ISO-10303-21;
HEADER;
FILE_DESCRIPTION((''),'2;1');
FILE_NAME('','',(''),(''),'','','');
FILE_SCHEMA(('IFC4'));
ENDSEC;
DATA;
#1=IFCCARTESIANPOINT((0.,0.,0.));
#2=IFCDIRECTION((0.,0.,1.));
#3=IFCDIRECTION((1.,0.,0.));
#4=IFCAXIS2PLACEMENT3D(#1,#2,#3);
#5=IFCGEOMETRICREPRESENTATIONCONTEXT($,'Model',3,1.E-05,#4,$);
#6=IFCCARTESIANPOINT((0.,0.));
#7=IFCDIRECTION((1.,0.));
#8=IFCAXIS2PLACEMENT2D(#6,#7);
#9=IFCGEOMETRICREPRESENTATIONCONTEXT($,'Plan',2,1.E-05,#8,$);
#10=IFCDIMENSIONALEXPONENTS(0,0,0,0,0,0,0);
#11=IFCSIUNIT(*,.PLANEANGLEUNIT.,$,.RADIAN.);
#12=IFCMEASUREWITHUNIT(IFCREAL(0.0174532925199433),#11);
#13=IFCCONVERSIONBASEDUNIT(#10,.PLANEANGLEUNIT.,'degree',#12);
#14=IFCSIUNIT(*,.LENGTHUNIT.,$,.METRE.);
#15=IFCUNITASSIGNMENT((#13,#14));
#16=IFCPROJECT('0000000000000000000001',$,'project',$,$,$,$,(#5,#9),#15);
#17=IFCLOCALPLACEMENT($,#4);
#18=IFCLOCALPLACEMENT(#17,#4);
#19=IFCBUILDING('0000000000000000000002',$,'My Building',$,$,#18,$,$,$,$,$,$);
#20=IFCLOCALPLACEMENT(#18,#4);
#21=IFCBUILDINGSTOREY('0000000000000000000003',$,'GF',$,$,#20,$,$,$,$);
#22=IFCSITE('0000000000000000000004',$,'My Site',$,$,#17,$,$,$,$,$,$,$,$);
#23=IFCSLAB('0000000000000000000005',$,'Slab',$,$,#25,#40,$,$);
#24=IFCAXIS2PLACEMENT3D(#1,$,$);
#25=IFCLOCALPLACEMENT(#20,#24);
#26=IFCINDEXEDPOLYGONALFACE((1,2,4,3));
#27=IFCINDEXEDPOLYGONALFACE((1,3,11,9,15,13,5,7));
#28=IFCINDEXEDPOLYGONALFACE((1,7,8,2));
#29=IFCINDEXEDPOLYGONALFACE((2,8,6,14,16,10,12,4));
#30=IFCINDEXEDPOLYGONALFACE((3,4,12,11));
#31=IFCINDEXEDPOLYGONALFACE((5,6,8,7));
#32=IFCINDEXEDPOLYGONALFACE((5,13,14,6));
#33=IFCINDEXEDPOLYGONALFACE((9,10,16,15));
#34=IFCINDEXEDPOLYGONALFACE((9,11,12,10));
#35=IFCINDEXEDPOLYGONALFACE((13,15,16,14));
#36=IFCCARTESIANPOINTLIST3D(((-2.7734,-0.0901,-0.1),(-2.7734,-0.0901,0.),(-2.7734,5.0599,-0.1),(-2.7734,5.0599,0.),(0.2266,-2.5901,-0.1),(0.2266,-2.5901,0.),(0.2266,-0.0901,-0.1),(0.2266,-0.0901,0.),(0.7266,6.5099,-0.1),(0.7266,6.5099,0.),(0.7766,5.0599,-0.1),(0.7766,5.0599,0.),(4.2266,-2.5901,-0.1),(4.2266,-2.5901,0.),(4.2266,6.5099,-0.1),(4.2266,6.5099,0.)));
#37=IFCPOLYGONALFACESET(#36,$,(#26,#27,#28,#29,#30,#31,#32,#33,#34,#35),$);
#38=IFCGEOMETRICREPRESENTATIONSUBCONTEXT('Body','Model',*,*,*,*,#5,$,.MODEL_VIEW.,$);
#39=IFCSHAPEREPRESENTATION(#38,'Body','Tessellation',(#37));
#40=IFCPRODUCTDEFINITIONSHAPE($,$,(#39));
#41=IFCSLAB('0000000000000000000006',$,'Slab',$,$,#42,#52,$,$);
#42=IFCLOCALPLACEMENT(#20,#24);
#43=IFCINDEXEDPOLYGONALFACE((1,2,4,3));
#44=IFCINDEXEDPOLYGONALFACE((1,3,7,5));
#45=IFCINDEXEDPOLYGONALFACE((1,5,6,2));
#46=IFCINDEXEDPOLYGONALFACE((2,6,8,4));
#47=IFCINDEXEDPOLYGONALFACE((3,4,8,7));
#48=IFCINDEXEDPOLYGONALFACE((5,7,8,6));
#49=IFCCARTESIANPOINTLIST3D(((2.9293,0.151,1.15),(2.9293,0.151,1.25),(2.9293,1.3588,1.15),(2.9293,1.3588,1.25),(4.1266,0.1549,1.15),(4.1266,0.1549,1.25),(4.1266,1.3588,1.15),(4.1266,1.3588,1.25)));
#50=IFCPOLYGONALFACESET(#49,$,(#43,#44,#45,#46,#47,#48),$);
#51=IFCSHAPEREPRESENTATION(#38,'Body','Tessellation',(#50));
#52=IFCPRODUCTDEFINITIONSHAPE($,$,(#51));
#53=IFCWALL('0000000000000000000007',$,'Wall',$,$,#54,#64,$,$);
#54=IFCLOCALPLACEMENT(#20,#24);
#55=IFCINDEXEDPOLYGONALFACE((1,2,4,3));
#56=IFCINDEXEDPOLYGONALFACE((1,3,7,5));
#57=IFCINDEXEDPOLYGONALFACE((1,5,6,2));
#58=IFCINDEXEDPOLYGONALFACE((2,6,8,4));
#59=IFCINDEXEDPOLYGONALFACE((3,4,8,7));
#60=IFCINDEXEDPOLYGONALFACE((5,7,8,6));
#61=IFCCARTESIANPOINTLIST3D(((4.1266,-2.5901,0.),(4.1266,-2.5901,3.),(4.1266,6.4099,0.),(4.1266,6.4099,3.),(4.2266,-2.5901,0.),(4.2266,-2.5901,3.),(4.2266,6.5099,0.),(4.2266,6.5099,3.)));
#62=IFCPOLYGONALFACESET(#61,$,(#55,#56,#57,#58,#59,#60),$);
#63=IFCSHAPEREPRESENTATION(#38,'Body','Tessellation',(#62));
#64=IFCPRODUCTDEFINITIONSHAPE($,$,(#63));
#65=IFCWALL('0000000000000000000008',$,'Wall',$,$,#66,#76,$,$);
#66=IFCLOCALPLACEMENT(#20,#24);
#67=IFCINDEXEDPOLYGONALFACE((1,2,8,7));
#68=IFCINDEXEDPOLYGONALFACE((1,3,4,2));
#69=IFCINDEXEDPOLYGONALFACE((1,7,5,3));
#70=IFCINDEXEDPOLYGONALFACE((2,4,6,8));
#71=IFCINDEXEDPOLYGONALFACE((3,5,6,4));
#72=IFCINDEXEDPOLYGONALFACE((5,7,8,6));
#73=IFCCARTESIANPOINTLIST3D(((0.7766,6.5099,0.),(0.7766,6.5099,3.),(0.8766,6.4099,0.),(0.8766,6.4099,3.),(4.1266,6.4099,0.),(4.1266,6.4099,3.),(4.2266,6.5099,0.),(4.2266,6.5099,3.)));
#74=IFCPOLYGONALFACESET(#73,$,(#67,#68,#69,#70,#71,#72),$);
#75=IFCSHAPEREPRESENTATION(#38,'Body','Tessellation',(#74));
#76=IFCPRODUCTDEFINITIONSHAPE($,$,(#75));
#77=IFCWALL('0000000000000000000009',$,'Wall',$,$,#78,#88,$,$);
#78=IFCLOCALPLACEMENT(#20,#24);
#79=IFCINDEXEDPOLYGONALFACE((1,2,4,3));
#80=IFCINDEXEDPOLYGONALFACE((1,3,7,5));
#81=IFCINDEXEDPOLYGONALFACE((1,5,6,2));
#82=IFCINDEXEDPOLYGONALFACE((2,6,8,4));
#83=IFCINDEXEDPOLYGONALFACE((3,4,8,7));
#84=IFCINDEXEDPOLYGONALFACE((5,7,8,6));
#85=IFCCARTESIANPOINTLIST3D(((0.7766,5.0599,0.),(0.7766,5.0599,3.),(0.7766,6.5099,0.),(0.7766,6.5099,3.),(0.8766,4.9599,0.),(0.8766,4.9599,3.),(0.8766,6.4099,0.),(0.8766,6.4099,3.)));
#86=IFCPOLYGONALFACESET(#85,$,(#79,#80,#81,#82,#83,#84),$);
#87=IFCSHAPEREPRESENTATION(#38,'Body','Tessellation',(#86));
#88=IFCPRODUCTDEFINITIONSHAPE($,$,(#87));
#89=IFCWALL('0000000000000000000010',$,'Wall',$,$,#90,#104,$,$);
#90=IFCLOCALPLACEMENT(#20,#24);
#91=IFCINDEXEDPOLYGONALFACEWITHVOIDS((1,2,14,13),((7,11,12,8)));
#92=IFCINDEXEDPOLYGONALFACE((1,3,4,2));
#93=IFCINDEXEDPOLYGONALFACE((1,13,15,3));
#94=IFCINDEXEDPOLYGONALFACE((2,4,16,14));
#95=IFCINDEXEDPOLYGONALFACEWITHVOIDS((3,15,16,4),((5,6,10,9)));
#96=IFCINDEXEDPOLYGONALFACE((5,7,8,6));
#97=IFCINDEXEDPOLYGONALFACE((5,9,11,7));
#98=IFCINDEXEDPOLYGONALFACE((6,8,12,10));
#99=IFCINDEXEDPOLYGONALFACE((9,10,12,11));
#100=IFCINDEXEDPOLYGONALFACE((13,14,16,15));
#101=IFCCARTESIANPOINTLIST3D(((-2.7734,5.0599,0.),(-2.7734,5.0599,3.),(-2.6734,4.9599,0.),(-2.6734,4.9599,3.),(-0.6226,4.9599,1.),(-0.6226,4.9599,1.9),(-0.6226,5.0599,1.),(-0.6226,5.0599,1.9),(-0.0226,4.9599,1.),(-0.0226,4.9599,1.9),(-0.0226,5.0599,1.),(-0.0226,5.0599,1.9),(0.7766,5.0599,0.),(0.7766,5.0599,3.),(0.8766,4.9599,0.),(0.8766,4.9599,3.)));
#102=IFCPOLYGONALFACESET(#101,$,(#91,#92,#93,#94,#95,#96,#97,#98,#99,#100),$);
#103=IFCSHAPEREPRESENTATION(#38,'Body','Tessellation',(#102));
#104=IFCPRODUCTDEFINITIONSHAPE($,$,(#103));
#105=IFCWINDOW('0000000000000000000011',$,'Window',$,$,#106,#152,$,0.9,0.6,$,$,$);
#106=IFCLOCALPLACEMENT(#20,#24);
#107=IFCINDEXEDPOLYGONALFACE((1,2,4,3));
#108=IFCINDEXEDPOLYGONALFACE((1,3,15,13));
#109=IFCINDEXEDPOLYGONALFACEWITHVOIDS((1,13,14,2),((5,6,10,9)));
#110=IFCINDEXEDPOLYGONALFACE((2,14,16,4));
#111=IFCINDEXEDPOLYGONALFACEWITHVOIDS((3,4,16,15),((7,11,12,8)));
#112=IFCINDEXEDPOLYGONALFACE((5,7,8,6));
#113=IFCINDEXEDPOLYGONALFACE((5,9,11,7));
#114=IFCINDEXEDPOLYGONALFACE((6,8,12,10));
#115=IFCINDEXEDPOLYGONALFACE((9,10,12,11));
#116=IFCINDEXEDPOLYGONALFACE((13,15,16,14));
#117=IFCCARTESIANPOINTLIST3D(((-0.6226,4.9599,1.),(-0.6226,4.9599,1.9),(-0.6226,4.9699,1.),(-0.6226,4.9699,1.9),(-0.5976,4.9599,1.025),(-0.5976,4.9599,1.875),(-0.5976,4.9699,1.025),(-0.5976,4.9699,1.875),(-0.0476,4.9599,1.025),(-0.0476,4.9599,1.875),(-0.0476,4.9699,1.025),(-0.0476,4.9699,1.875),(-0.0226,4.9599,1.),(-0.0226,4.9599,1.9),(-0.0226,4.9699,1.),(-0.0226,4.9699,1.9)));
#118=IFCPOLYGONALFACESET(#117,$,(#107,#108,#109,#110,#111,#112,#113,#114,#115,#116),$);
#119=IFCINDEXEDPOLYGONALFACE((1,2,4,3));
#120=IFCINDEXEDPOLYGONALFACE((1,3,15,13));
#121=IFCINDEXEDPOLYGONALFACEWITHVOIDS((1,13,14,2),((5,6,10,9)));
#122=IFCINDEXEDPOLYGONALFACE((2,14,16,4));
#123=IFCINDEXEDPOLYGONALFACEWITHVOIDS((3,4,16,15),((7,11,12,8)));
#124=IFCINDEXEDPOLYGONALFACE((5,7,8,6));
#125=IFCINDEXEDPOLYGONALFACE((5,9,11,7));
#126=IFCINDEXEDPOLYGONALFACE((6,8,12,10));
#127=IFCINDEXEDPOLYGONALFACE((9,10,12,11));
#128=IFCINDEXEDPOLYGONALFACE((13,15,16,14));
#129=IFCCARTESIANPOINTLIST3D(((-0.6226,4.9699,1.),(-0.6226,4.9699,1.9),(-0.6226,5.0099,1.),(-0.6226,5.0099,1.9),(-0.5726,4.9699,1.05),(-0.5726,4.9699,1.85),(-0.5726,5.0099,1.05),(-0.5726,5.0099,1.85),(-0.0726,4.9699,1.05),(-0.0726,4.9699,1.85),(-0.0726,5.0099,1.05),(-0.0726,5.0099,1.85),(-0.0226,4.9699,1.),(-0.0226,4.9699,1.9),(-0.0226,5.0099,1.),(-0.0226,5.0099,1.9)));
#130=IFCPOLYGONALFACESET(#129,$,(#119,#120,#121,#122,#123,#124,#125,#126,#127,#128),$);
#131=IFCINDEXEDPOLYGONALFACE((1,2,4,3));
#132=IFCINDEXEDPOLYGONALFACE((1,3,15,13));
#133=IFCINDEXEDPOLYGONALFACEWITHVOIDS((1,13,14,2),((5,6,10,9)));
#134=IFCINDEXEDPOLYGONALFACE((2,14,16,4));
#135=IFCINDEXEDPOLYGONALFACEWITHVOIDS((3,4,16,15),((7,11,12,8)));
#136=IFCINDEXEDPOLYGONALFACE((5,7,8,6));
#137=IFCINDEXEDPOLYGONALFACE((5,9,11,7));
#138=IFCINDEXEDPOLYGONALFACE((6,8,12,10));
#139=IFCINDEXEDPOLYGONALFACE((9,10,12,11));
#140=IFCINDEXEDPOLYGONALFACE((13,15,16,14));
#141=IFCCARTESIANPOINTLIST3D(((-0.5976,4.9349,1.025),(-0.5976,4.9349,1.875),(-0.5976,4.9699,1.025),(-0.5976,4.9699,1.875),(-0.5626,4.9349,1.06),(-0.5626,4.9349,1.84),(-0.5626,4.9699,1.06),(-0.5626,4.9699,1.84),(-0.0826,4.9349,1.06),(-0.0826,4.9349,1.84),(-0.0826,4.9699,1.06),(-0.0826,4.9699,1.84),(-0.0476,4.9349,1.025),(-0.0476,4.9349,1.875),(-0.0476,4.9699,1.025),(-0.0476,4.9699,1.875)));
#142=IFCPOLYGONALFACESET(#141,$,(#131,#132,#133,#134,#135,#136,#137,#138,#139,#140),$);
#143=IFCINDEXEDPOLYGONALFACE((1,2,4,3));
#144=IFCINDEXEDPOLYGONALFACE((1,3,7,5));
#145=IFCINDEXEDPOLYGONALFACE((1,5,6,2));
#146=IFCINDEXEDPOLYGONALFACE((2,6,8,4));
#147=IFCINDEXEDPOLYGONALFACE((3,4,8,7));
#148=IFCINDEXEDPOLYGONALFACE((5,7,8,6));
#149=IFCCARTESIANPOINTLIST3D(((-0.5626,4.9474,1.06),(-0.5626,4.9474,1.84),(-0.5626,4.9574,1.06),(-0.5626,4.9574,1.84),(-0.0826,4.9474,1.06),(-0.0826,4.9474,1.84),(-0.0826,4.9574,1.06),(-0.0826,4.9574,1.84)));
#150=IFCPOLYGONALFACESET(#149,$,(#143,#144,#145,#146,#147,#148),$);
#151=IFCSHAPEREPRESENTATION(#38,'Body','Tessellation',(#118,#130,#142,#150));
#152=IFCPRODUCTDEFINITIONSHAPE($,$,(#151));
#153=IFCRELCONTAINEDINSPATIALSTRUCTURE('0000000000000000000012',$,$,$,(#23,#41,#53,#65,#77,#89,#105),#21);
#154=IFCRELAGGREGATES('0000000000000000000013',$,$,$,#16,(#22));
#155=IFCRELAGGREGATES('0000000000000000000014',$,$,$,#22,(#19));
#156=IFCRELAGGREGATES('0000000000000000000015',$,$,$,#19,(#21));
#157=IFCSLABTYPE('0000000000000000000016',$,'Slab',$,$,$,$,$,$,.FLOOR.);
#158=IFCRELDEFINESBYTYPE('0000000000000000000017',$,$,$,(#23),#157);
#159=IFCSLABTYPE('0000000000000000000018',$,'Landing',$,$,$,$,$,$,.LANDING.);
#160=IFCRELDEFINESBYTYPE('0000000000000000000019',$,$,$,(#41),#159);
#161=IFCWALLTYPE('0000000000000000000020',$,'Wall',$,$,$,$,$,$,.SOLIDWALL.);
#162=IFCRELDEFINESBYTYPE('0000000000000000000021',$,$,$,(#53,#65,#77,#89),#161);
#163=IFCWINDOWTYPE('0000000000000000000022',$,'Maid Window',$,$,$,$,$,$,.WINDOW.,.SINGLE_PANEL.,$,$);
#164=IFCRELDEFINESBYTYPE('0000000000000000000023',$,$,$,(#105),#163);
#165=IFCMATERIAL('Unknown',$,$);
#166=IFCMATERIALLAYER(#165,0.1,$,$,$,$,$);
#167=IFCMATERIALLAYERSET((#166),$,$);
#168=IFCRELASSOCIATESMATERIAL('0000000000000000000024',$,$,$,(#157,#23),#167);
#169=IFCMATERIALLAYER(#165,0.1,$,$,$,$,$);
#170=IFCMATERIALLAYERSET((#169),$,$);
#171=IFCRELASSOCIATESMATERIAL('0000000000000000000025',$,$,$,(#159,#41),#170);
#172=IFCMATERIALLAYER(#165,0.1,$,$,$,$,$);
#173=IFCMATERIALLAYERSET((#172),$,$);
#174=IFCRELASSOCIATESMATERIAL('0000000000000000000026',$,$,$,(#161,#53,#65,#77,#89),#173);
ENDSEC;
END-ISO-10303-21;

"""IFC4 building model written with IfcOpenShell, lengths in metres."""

from ifc_helpers import new_model, entity, si_unit, converted_unit, frame, origin_with_axes, origin_2d_with_axis, place, context, subcontext, project, spatial, line, indexed_curve, outline, extrude, shape, source, transform, mapped, material, layer, layer_set, layer_usage, type_object, type_shapes, element, fill, save


model = new_model("IFC4")

# Units and contexts
model_context = context("Model", 3, precision=1e-05, world=origin_with_axes())
plan_context = context("Plan", 2, precision=1e-05, world=origin_2d_with_axis())
body_context_1 = subcontext(model_context, "Body", "Model", "MODEL_VIEW")
body_context_2 = subcontext(plan_context, "Body", "Plan", "PLAN_VIEW")
ifc_project = project(units=[converted_unit("PLANEANGLEUNIT", "degree", entity("IfcReal", 0.0174532925199433), si_unit("PLANEANGLEUNIT", "RADIAN"), dimensions=[0, 0, 0, 0, 0, 0, 0]), si_unit("LENGTHUNIT", "METRE")], contexts=[model_context, plan_context])

# Site, building, storey
site_placement = place(None, origin_with_axes())
site = spatial("IfcSite", under=ifc_project, at=site_placement, Name="My Site")
building_placement = place(site_placement, origin_with_axes())
building = spatial("IfcBuilding", under=site, at=building_placement, Name="My Building")
storey_placement = place(building_placement, origin_with_axes())
storey = spatial("IfcBuildingStorey", under=building, at=storey_placement, Name="GF")

# Slabs
ifc_material_1 = material(Name="Unknown")
ifc_layer_1 = layer(ifc_material_1, 0.1)
ifc_layer_set_1 = layer_set([ifc_layer_1])
ifc_layer_usage_1 = layer_usage(ifc_layer_set_1, "AXIS3", "POSITIVE", -0.1)
slab_type_1 = type_object("IfcSlabType", Name="Slab", PredefinedType="FLOOR", material=ifc_layer_set_1)
slab_1_placement = place(storey_placement, frame((4.2266, -2.5901, 0.0), z_axis=(0.0, 0.0, 1.0), x_axis=(1.0, 0.0, 0.0)))
element("IfcSlab", 1, at=slab_1_placement, inside=storey, type_object=slab_type_1, material=ifc_layer_usage_1, Name="Slab", context=body_context_1, shape_type="SweptSolid", body=[
    extrude(outline(indexed_curve([(0.0, 0.0), (0.0, 9.1), (-3.5, 9.1), (-3.45, 7.65), (-7.0, 7.65), (-7.0, 2.5), (-4.0, 2.5), (-4.0, 0.0), (0.0, 0.0)])), frame((0.0, 0.0, -0.1), z_axis=(0.0, 0.0, 1.0), x_axis=(1.0, 0.0, 0.0)), (0.0, 0.0, 1.0), 0.1),
])
ifc_layer_2 = layer(ifc_material_1, 0.1)
ifc_layer_set_2 = layer_set([ifc_layer_2])
ifc_layer_usage_2 = layer_usage(ifc_layer_set_2, "AXIS3", "POSITIVE", -0.1)
slab_type_2 = type_object("IfcSlabType", Name="Landing", PredefinedType="LANDING", material=ifc_layer_set_2)
slab_2_placement = place(storey_placement, frame((4.1266, 0.1549, 1.25), z_axis=(0.0, 0.0, 1.0), x_axis=(1.0, 0.0, 0.0)))
element("IfcSlab", 2, at=slab_2_placement, inside=storey, type_object=slab_type_2, material=ifc_layer_usage_2, Name="Slab", context=body_context_1, shape_type="SweptSolid", body=[
    extrude(outline(indexed_curve([(0.0, 0.0), (-1.1973, -0.0039), (-1.1973, 1.204), (0.0, 1.204), (0.0, 0.0)])), frame((0.0, 0.0, -0.1), z_axis=(0.0, 0.0, 1.0), x_axis=(1.0, 0.0, 0.0)), (0.0, 0.0, 1.0), 0.1),
])

# Shared definitions
ifc_layer_3 = layer(ifc_material_1, 0.1)
ifc_layer_set_3 = layer_set([ifc_layer_3])
wall_type = type_object("IfcWallType", Name="Wall", PredefinedType="SOLIDWALL", material=ifc_layer_set_3)

# Walls
ifc_layer_usage_3 = layer_usage(ifc_layer_set_3, "AXIS2", "POSITIVE", 0.0)
wall_1_placement = place(storey_placement, frame((4.2266, -2.5901, 0.0), z_axis=(0.0, 0.0, 1.0), x_axis=(0.0, 1.0, 0.0)))
element("IfcWall", 3, at=wall_1_placement, inside=storey, type_object=wall_type, material=ifc_layer_usage_3, Name="Wall", context=body_context_1, shape_type="SweptSolid", body=[
    extrude(outline(indexed_curve([(0.0, 0.0), (0.0, 0.1), (9.0, 0.1), (9.1, 0.0)], segments=[line(1, 2, 3, 4, 1)])), origin_with_axes(), (0.0, 0.0, 1.0), 3.0),
])
ifc_layer_usage_4 = layer_usage(ifc_layer_set_3, "AXIS2", "POSITIVE", 0.0)
wall_2_placement = place(storey_placement, frame((4.2266, 6.5099, 0.0), z_axis=(0.0, 0.0, 1.0), x_axis=(-1.0, 0.0, 0.0)))
element("IfcWall", 4, at=wall_2_placement, inside=storey, type_object=wall_type, material=ifc_layer_usage_4, Name="Wall", context=body_context_1, shape_type="SweptSolid", body=[
    extrude(outline(indexed_curve([(0.0, 0.0), (0.1, 0.1), (3.35, 0.1), (3.45, 0.0)], segments=[line(1, 2, 3, 4, 1)])), origin_with_axes(), (0.0, 0.0, 1.0), 3.0),
])
ifc_layer_usage_5 = layer_usage(ifc_layer_set_3, "AXIS2", "POSITIVE", 0.0)
wall_3_placement = place(storey_placement, frame((0.7766, 6.5099, 0.0), z_axis=(0.0, 0.0, 1.0), x_axis=(0.0, -1.0, 0.0)))
element("IfcWall", 5, at=wall_3_placement, inside=storey, type_object=wall_type, material=ifc_layer_usage_5, Name="Wall", context=body_context_1, shape_type="SweptSolid", body=[
    extrude(outline(indexed_curve([(0.0, 0.0), (0.1, 0.1), (1.55, 0.1), (1.45, 0.0)], segments=[line(1, 2, 3, 4, 1)])), origin_with_axes(), (0.0, 0.0, 1.0), 3.0),
])

# Wall, opening, window
ifc_layer_usage_6 = layer_usage(ifc_layer_set_3, "AXIS2", "POSITIVE", 0.0)
wall_4_placement = place(storey_placement, frame((0.7766, 5.0599, 0.0), z_axis=(0.0, 0.0, 1.0), x_axis=(-1.0, 0.0, 0.0)))
wall_4 = element("IfcWall", 6, at=wall_4_placement, inside=storey, type_object=wall_type, material=ifc_layer_usage_6, Name="Wall", context=body_context_1, shape_type="SweptSolid", body=[
    extrude(outline(indexed_curve([(0.0, 0.0), (-0.1, 0.1), (3.45, 0.1), (3.55, 0.0)], segments=[line(1, 2, 3, 4, 1)])), origin_with_axes(), (0.0, 0.0, 1.0), 3.0),
])
shared_shape_1 = source(origin_with_axes(), body_context_1, "Body", "SweptSolid", [
    extrude(outline(indexed_curve([(0.0, 0.0), (0.6, 0.0), (0.6, 0.9), (0.0, 0.9)], segments=[line(1, 2, 3, 4, 1)])), frame((0.0, -0.6, 0.0), z_axis=(0.0, -1.0, 0.0), x_axis=(1.0, 0.0, 0.0)), (0.0, 0.0, -1.0), 1.2),
])
opening_1_placement = place(wall_4_placement, frame((0.7992, 0.0, 1.0), z_axis=(0.0, 0.0, 1.0), x_axis=(1.0, 0.0, 0.0)))
opening_1 = element("IfcOpeningElement", 7, at=opening_1_placement, cuts=wall_4, PredefinedType="OPENING", context=body_context_1, shape_type="MappedRepresentation", body=[
    mapped(shared_shape_1, transform((0.0, 0.0, 0.0), x_axis=(1.0, 0.0, 0.0), y_axis=(0.0, 1.0, 0.0), z_axis=(0.0, 0.0, 1.0), scale=1.0)),
])
window_type_1 = type_object("IfcWindowType", Name="Maid Window", PartitioningType="SINGLE_PANEL", PredefinedType="WINDOW")
shared_shape_2 = source(origin_with_axes(), body_context_1, "Body", "SweptSolid", [
    extrude(outline(indexed_curve([(0.0, 0.0), (0.6, 0.0), (0.6, 0.9), (0.0, 0.9)], segments=[line(1, 2, 3, 4, 1)]), holes=[indexed_curve([(0.025, 0.025), (0.575, 0.025), (0.575, 0.875), (0.025, 0.875)], segments=[line(1, 2, 3, 4, 1)])]), frame((0.0, 0.09, 0.0), z_axis=(0.0, -1.0, 0.0), x_axis=(1.0, 0.0, 0.0)), (0.0, 0.0, -1.0), 0.01),
    extrude(outline(indexed_curve([(0.0, 0.0), (0.6, 0.0), (0.6, 0.9), (0.0, 0.9)], segments=[line(1, 2, 3, 4, 1)]), holes=[indexed_curve([(0.05, 0.05), (0.55, 0.05), (0.55, 0.85), (0.05, 0.85)], segments=[line(1, 2, 3, 4, 1)])]), frame((0.0, 0.05, 0.0), z_axis=(0.0, -1.0, 0.0), x_axis=(1.0, 0.0, 0.0)), (0.0, 0.0, -1.0), 0.04),
    extrude(outline(indexed_curve([(0.0, 0.0), (0.55, 0.0), (0.55, 0.85), (0.0, 0.85)], segments=[line(1, 2, 3, 4, 1)]), holes=[indexed_curve([(0.035, 0.035), (0.515, 0.035), (0.515, 0.815), (0.035, 0.815)], segments=[line(1, 2, 3, 4, 1)])]), frame((0.025, 0.09, 0.025), z_axis=(0.0, -1.0, 0.0), x_axis=(1.0, 0.0, 0.0)), (0.0, 0.0, -1.0), 0.035),
    extrude(outline(indexed_curve([(0.035, 0.035), (0.515, 0.035), (0.515, 0.815), (0.035, 0.815)], segments=[line(1, 2, 3, 4, 1)])), frame((0.025, 0.1025, 0.025), z_axis=(0.0, -1.0, 0.0), x_axis=(1.0, 0.0, 0.0)), (0.0, 0.0, -1.0), 0.01),
])
shared_shape_3 = source(origin_with_axes(), body_context_2, "Body", "Curve2D", [
    entity("IfcIndexedPolyCurve", entity("IfcCartesianPointList2D", [[0.05, 0.05], [0.55, 0.05]])),
    entity("IfcIndexedPolyCurve", entity("IfcCartesianPointList2D", [[0.0, 0.1], [0.025, 0.1], [0.025, 0.09], [0.05, 0.09], [0.05, 0.05], [0.0, 0.05]]), [entity("IfcLineIndex", [1, 2, 3, 4, 5, 6, 1])]),
    entity("IfcIndexedPolyCurve", entity("IfcCartesianPointList2D", [[0.6, 0.1], [0.575, 0.1], [0.575, 0.09], [0.55, 0.09], [0.55, 0.05], [0.6, 0.05]]), [entity("IfcLineIndex", [1, 2, 3, 4, 5, 6, 1])]),
    entity("IfcIndexedPolyCurve", entity("IfcCartesianPointList2D", [[0.025, 0.09], [0.06, 0.09], [0.06, 0.125], [0.025, 0.125]]), [entity("IfcLineIndex", [1, 2, 3, 4, 1])]),
    entity("IfcIndexedPolyCurve", entity("IfcCartesianPointList2D", [[0.575, 0.09], [0.54, 0.09], [0.54, 0.125], [0.575, 0.125]]), [entity("IfcLineIndex", [1, 2, 3, 4, 1])]),
    entity("IfcIndexedPolyCurve", entity("IfcCartesianPointList2D", [[0.06, 0.09], [0.54, 0.09]])),
    entity("IfcIndexedPolyCurve", entity("IfcCartesianPointList2D", [[0.06, 0.125], [0.54, 0.125]])),
    entity("IfcIndexedPolyCurve", entity("IfcCartesianPointList2D", [[0.06, 0.1075], [0.54, 0.1075]])),
])
type_shapes(window_type_1, [shared_shape_2, shared_shape_3])
window_1_placement = place(opening_1_placement, frame((0.0, 0.0, 0.0), z_axis=(0.0, 0.0, 1.0), x_axis=(1.0, 0.0, 0.0)))
window_1 = element("IfcWindow", 8, at=window_1_placement, inside=storey, type_object=window_type_1, Name="Window", OverallHeight=0.9, OverallWidth=0.6, shapes=[
    shape(body_context_1, "Body", "MappedRepresentation", [mapped(shared_shape_2, transform((0.0, 0.0, 0.0), x_axis=(1.0, 0.0, 0.0), y_axis=(0.0, 1.0, 0.0), z_axis=(0.0, 0.0, 1.0), scale=1.0))]),
    shape(body_context_2, "Body", "MappedRepresentation", [mapped(shared_shape_3, transform((0.0, 0.0, 0.0), x_axis=(1.0, 0.0, 0.0), y_axis=(0.0, 1.0, 0.0), z_axis=(0.0, 0.0, 1.0), scale=1.0))]),
])
fill(opening_1, window_1)

save(model, "model.ifc")
